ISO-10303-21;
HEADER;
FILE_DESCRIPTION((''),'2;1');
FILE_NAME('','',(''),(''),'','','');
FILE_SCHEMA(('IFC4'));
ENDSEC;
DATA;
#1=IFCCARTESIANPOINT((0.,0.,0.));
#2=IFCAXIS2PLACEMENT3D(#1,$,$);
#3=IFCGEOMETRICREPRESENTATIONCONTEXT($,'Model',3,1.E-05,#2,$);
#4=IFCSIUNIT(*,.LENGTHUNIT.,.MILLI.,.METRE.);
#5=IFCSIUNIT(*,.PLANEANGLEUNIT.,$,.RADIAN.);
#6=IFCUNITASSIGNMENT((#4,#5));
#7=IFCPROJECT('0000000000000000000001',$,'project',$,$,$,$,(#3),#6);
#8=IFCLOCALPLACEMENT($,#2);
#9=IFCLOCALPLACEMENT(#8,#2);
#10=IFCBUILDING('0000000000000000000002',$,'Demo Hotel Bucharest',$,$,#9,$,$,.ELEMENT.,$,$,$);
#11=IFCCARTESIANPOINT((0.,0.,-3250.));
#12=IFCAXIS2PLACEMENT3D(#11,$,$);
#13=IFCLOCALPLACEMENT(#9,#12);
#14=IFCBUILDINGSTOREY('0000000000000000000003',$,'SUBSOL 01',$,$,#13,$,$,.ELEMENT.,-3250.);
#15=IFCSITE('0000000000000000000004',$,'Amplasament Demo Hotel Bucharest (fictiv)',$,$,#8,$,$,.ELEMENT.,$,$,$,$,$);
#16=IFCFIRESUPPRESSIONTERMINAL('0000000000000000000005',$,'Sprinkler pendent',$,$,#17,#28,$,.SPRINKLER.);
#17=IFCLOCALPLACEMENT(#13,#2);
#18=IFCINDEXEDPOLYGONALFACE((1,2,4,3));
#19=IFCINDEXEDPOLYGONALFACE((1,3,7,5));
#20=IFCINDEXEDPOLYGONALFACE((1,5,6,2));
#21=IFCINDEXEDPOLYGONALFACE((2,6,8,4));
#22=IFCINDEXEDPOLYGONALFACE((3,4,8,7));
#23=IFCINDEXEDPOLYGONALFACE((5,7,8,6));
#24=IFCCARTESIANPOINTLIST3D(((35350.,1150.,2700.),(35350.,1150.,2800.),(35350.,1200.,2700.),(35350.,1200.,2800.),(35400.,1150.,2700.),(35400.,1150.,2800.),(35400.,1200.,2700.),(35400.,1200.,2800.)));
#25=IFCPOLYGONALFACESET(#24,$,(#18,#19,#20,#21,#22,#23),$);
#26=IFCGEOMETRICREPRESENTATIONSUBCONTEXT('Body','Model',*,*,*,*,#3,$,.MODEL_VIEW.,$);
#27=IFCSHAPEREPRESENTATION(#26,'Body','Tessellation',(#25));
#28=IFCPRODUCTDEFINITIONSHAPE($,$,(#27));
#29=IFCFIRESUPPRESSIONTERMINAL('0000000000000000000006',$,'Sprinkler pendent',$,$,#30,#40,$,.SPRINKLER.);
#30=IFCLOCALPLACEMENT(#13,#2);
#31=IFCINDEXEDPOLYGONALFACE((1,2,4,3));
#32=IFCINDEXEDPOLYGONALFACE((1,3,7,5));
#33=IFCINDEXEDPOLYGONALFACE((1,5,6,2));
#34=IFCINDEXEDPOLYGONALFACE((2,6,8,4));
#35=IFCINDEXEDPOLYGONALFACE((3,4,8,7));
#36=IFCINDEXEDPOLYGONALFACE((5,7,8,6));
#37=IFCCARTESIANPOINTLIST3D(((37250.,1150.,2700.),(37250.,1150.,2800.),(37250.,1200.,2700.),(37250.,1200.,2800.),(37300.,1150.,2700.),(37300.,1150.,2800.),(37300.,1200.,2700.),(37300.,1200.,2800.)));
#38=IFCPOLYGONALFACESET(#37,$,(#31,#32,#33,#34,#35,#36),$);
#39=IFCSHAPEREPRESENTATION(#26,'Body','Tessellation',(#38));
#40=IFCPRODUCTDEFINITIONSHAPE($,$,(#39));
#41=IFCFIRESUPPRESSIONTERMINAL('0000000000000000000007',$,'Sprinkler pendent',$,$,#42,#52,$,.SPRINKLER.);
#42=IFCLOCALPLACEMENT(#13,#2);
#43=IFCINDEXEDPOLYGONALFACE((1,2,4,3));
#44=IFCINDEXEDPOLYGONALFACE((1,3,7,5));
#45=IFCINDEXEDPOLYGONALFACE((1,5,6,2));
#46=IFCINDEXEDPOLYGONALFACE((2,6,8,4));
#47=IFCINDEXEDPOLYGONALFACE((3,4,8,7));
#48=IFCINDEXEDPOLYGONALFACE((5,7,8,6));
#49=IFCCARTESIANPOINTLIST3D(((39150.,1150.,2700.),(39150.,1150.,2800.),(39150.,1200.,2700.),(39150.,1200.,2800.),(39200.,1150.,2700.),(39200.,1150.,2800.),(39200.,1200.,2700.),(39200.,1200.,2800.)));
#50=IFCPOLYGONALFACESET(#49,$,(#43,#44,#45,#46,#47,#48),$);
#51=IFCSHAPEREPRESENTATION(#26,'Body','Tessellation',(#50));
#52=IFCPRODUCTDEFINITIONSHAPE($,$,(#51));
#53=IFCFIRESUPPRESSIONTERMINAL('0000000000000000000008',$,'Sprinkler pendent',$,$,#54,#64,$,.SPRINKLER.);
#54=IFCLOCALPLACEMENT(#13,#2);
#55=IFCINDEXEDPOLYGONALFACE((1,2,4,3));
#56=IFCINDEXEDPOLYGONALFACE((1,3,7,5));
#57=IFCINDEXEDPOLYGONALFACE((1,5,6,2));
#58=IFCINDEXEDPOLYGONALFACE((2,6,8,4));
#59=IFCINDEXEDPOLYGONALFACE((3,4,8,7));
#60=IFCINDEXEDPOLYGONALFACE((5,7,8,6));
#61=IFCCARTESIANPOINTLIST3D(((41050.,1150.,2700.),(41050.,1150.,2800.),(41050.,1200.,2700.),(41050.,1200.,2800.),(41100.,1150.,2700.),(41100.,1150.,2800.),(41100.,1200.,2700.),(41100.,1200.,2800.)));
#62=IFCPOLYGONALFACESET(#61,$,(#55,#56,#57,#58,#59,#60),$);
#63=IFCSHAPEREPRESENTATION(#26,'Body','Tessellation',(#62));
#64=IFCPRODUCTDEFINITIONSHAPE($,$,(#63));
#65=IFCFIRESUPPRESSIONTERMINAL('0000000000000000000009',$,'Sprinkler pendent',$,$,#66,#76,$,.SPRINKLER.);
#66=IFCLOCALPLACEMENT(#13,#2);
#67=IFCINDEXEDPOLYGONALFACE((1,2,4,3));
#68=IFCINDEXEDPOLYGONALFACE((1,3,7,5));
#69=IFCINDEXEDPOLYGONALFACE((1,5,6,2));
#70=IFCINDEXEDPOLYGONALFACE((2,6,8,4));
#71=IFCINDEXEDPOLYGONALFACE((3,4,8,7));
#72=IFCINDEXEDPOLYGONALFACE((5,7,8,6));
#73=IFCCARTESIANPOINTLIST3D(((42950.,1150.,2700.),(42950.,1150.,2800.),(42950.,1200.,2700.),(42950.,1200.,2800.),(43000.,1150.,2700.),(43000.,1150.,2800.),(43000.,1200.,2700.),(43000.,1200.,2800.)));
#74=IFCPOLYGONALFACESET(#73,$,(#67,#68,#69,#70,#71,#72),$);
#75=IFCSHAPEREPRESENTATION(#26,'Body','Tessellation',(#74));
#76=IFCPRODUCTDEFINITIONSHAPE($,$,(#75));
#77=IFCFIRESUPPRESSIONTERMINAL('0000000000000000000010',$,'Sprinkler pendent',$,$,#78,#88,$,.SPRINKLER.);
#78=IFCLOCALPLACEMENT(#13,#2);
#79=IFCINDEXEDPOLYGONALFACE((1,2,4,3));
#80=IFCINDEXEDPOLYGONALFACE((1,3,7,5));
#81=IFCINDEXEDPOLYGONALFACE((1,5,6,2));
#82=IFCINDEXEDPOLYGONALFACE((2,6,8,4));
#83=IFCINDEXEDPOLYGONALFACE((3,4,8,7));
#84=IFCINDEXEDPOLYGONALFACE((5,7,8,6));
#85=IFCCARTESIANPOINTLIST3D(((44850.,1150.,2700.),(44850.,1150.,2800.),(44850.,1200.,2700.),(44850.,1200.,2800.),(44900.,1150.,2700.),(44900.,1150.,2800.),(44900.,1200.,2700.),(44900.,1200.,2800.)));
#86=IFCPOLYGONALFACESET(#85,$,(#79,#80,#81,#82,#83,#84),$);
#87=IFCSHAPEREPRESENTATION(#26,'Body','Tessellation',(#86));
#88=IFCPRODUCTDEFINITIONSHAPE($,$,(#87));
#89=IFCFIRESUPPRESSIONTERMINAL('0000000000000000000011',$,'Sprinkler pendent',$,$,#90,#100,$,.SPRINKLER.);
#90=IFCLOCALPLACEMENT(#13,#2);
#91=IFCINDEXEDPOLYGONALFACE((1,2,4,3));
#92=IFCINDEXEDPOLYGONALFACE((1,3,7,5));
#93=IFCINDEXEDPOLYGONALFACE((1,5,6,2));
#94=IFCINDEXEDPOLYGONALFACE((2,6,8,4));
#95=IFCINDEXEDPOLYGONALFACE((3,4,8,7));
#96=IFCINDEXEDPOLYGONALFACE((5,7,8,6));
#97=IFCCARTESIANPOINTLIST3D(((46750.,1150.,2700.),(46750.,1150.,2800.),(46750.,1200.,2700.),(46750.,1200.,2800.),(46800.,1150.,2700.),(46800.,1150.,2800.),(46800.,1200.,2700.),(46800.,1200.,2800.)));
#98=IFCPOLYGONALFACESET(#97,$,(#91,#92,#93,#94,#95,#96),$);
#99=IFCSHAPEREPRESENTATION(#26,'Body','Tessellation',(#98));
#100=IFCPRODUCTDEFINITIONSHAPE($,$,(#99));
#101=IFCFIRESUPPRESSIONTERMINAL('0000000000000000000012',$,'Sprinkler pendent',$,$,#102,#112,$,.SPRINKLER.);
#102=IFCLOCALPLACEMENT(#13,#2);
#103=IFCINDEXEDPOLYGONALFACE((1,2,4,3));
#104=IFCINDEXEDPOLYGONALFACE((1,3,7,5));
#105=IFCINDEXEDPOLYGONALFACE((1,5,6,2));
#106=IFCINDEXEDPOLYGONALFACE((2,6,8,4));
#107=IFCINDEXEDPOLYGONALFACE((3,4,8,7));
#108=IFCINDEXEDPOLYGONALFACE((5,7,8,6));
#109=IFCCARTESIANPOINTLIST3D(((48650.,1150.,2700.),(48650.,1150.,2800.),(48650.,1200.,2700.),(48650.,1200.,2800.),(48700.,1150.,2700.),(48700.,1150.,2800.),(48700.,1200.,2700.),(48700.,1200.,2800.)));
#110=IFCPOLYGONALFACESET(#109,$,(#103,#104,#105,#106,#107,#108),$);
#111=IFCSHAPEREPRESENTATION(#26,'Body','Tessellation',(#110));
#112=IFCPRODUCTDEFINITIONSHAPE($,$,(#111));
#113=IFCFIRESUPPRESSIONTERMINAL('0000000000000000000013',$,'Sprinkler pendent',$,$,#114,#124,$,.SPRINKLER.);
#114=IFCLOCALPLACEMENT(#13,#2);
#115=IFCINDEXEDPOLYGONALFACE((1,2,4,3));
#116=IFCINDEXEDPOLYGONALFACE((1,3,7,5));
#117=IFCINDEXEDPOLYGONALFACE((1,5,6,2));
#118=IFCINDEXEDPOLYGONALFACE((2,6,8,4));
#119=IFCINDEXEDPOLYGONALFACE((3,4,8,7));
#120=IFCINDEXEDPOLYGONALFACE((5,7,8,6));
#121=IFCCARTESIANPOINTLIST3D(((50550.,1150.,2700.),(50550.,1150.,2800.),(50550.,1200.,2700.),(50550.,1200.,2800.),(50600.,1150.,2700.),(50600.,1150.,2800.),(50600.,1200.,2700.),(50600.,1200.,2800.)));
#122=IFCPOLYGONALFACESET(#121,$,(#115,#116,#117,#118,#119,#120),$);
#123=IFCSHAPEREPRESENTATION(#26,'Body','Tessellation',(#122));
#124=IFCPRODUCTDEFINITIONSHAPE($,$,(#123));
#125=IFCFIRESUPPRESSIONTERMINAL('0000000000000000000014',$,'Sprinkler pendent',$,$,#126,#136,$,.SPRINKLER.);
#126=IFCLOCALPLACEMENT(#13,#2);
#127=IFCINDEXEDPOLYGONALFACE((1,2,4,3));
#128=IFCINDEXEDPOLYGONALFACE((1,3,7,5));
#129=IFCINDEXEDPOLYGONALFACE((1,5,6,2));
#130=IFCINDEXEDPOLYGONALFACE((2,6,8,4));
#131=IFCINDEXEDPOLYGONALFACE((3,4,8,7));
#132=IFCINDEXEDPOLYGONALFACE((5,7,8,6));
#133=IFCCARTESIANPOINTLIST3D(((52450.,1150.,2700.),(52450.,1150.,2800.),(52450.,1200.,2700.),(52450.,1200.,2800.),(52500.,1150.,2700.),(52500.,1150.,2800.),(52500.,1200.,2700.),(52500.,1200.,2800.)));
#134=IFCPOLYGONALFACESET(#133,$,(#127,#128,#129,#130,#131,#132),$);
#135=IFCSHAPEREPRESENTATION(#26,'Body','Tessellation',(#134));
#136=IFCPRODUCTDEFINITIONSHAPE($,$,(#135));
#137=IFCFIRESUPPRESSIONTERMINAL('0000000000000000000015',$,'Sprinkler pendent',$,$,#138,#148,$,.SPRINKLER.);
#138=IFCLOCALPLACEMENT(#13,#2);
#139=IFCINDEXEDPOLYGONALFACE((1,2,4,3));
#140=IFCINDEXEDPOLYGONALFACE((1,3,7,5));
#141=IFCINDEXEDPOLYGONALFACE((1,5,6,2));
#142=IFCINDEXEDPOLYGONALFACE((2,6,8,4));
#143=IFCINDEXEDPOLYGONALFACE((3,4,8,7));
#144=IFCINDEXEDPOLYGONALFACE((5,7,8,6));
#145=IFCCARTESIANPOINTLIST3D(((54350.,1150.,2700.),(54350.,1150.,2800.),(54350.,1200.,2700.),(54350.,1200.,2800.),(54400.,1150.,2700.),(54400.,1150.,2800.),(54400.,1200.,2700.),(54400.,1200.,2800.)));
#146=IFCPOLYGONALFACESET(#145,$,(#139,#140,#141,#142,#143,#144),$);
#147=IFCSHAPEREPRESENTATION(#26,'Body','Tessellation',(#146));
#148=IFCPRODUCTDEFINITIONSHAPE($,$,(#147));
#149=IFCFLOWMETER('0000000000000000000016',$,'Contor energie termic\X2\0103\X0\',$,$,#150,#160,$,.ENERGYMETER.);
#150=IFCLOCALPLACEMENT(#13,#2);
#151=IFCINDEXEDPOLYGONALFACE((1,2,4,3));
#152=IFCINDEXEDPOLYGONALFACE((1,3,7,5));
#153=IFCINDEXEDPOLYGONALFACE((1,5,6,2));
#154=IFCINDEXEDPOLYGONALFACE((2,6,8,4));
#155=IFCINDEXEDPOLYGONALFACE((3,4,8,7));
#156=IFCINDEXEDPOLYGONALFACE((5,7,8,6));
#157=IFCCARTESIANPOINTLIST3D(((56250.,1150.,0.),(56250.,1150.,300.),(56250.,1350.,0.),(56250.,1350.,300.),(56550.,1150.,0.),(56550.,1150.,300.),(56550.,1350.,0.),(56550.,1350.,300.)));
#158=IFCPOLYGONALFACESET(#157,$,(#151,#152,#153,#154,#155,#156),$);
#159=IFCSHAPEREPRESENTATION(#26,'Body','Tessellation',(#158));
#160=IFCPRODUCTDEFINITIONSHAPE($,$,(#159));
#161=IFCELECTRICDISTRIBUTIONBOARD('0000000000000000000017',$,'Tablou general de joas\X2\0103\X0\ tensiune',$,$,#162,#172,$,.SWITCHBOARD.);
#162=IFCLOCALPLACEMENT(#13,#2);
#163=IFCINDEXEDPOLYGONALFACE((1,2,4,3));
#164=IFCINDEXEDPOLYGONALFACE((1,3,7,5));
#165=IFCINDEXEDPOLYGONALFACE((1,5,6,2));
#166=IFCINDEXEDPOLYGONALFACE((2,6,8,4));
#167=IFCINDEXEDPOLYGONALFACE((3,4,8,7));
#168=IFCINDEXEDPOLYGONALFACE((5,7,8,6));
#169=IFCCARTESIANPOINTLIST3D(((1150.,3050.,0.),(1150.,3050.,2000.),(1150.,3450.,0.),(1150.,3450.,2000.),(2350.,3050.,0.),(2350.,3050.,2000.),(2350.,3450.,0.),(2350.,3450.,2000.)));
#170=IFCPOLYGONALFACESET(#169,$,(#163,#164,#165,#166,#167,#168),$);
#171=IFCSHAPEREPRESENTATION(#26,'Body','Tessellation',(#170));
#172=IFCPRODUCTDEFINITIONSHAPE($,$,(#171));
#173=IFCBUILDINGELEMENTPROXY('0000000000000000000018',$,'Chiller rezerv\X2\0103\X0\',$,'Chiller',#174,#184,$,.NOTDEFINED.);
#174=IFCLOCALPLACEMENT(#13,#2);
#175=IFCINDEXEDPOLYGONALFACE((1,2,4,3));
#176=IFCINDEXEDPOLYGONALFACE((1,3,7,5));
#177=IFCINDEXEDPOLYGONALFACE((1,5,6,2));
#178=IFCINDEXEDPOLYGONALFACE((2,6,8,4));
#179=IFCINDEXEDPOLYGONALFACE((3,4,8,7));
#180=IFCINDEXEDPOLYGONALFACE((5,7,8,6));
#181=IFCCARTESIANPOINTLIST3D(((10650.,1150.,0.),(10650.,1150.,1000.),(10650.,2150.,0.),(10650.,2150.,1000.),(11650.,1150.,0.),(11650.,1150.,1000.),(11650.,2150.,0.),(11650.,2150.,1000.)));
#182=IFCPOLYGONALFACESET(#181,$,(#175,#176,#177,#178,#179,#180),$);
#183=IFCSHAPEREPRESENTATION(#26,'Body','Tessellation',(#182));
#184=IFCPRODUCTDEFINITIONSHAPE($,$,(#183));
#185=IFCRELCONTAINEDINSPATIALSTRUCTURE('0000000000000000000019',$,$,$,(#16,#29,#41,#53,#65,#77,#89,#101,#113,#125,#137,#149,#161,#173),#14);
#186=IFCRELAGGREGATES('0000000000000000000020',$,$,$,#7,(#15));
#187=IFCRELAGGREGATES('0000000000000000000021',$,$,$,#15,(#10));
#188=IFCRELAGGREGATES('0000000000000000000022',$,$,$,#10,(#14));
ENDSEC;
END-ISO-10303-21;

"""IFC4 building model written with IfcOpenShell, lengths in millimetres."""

from ifc_helpers import new_model, si_unit, frame, frame_2d, origin, place, context, subcontext, project, spatial, rectangle, extrude, element, save


model = new_model("IFC4")

# Units and contexts
model_context = context("Model", 3, precision=1e-05, world=origin())
body_context = subcontext(model_context, "Body", "Model", "MODEL_VIEW")
ifc_project = project(units=[si_unit("LENGTHUNIT", "METRE", prefix="MILLI"), si_unit("PLANEANGLEUNIT", "RADIAN")], contexts=[model_context])

# Site, building, storey
site_placement = place(None, origin())
site = spatial("IfcSite", under=ifc_project, at=site_placement, Name="Amplasament Demo Hotel Bucharest (fictiv)", CompositionType="ELEMENT")
building_placement = place(site_placement, origin())
building = spatial("IfcBuilding", under=site, at=building_placement, Name="Demo Hotel Bucharest", CompositionType="ELEMENT")
storey_placement = place(building_placement, frame((0.0, 0.0, -3250.0)))
storey = spatial("IfcBuildingStorey", under=building, at=storey_placement, Name="SUBSOL 01", CompositionType="ELEMENT", Elevation=-3250.0)

# Fire suppression terminals
for number, where, name in (
    (1, (35350.0, 1150.0, 2700.0), "Sprinkler pendent"),
    (2, (37250.0, 1150.0, 2700.0), "Sprinkler pendent"),
    (3, (39150.0, 1150.0, 2700.0), "Sprinkler pendent"),
    (4, (41050.0, 1150.0, 2700.0), "Sprinkler pendent"),
    (5, (42950.0, 1150.0, 2700.0), "Sprinkler pendent"),
    (6, (44850.0, 1150.0, 2700.0), "Sprinkler pendent"),
    (7, (46750.0, 1150.0, 2700.0), "Sprinkler pendent"),
    (8, (48650.0, 1150.0, 2700.0), "Sprinkler pendent"),
    (9, (50550.0, 1150.0, 2700.0), "Sprinkler pendent"),
    (10, (52450.0, 1150.0, 2700.0), "Sprinkler pendent"),
    (11, (54350.0, 1150.0, 2700.0), "Sprinkler pendent"),
):
    element("IfcFireSuppressionTerminal", number, at=place(storey_placement, frame(where)), inside=storey, Name=name, PredefinedType="SPRINKLER", context=body_context, shape_type="SweptSolid", body=[
        extrude(rectangle(XDim=50.0, YDim=50.0, at=frame_2d((25.0, 25.0))), origin(), (0.0, 0.0, 1.0), 100.0),
    ])

# Flow meter
flow_meter_placement = place(storey_placement, frame((56250.0, 1150.0, 0.0)))
element("IfcFlowMeter", 12, at=flow_meter_placement, inside=storey, Name="Contor energie termică", PredefinedType="ENERGYMETER", context=body_context, shape_type="SweptSolid", body=[
    extrude(rectangle(XDim=300.0, YDim=200.0, at=frame_2d((150.0, 100.0))), origin(), (0.0, 0.0, 1.0), 300.0),
])

# Electric distribution board
electric_distribution_board_placement = place(storey_placement, frame((1150.0, 3050.0, 0.0)))
element("IfcElectricDistributionBoard", 13, at=electric_distribution_board_placement, inside=storey, Name="Tablou general de joasă tensiune", PredefinedType="SWITCHBOARD", context=body_context, shape_type="SweptSolid", body=[
    extrude(rectangle(XDim=1200.0, YDim=400.0, at=frame_2d((600.0, 200.0))), origin(), (0.0, 0.0, 1.0), 2000.0),
])

# Building element proxy
proxy_placement = place(storey_placement, frame((10650.0, 1150.0, 0.0)))
element("IfcBuildingElementProxy", 14, at=proxy_placement, inside=storey, Name="Chiller rezervă", ObjectType="Chiller", PredefinedType="NOTDEFINED", context=body_context, shape_type="SweptSolid", body=[
    extrude(rectangle(XDim=1000.0, YDim=1000.0, at=frame_2d((500.0, 500.0))), origin(), (0.0, 0.0, 1.0), 1000.0),
])

save(model, "model.ifc")
